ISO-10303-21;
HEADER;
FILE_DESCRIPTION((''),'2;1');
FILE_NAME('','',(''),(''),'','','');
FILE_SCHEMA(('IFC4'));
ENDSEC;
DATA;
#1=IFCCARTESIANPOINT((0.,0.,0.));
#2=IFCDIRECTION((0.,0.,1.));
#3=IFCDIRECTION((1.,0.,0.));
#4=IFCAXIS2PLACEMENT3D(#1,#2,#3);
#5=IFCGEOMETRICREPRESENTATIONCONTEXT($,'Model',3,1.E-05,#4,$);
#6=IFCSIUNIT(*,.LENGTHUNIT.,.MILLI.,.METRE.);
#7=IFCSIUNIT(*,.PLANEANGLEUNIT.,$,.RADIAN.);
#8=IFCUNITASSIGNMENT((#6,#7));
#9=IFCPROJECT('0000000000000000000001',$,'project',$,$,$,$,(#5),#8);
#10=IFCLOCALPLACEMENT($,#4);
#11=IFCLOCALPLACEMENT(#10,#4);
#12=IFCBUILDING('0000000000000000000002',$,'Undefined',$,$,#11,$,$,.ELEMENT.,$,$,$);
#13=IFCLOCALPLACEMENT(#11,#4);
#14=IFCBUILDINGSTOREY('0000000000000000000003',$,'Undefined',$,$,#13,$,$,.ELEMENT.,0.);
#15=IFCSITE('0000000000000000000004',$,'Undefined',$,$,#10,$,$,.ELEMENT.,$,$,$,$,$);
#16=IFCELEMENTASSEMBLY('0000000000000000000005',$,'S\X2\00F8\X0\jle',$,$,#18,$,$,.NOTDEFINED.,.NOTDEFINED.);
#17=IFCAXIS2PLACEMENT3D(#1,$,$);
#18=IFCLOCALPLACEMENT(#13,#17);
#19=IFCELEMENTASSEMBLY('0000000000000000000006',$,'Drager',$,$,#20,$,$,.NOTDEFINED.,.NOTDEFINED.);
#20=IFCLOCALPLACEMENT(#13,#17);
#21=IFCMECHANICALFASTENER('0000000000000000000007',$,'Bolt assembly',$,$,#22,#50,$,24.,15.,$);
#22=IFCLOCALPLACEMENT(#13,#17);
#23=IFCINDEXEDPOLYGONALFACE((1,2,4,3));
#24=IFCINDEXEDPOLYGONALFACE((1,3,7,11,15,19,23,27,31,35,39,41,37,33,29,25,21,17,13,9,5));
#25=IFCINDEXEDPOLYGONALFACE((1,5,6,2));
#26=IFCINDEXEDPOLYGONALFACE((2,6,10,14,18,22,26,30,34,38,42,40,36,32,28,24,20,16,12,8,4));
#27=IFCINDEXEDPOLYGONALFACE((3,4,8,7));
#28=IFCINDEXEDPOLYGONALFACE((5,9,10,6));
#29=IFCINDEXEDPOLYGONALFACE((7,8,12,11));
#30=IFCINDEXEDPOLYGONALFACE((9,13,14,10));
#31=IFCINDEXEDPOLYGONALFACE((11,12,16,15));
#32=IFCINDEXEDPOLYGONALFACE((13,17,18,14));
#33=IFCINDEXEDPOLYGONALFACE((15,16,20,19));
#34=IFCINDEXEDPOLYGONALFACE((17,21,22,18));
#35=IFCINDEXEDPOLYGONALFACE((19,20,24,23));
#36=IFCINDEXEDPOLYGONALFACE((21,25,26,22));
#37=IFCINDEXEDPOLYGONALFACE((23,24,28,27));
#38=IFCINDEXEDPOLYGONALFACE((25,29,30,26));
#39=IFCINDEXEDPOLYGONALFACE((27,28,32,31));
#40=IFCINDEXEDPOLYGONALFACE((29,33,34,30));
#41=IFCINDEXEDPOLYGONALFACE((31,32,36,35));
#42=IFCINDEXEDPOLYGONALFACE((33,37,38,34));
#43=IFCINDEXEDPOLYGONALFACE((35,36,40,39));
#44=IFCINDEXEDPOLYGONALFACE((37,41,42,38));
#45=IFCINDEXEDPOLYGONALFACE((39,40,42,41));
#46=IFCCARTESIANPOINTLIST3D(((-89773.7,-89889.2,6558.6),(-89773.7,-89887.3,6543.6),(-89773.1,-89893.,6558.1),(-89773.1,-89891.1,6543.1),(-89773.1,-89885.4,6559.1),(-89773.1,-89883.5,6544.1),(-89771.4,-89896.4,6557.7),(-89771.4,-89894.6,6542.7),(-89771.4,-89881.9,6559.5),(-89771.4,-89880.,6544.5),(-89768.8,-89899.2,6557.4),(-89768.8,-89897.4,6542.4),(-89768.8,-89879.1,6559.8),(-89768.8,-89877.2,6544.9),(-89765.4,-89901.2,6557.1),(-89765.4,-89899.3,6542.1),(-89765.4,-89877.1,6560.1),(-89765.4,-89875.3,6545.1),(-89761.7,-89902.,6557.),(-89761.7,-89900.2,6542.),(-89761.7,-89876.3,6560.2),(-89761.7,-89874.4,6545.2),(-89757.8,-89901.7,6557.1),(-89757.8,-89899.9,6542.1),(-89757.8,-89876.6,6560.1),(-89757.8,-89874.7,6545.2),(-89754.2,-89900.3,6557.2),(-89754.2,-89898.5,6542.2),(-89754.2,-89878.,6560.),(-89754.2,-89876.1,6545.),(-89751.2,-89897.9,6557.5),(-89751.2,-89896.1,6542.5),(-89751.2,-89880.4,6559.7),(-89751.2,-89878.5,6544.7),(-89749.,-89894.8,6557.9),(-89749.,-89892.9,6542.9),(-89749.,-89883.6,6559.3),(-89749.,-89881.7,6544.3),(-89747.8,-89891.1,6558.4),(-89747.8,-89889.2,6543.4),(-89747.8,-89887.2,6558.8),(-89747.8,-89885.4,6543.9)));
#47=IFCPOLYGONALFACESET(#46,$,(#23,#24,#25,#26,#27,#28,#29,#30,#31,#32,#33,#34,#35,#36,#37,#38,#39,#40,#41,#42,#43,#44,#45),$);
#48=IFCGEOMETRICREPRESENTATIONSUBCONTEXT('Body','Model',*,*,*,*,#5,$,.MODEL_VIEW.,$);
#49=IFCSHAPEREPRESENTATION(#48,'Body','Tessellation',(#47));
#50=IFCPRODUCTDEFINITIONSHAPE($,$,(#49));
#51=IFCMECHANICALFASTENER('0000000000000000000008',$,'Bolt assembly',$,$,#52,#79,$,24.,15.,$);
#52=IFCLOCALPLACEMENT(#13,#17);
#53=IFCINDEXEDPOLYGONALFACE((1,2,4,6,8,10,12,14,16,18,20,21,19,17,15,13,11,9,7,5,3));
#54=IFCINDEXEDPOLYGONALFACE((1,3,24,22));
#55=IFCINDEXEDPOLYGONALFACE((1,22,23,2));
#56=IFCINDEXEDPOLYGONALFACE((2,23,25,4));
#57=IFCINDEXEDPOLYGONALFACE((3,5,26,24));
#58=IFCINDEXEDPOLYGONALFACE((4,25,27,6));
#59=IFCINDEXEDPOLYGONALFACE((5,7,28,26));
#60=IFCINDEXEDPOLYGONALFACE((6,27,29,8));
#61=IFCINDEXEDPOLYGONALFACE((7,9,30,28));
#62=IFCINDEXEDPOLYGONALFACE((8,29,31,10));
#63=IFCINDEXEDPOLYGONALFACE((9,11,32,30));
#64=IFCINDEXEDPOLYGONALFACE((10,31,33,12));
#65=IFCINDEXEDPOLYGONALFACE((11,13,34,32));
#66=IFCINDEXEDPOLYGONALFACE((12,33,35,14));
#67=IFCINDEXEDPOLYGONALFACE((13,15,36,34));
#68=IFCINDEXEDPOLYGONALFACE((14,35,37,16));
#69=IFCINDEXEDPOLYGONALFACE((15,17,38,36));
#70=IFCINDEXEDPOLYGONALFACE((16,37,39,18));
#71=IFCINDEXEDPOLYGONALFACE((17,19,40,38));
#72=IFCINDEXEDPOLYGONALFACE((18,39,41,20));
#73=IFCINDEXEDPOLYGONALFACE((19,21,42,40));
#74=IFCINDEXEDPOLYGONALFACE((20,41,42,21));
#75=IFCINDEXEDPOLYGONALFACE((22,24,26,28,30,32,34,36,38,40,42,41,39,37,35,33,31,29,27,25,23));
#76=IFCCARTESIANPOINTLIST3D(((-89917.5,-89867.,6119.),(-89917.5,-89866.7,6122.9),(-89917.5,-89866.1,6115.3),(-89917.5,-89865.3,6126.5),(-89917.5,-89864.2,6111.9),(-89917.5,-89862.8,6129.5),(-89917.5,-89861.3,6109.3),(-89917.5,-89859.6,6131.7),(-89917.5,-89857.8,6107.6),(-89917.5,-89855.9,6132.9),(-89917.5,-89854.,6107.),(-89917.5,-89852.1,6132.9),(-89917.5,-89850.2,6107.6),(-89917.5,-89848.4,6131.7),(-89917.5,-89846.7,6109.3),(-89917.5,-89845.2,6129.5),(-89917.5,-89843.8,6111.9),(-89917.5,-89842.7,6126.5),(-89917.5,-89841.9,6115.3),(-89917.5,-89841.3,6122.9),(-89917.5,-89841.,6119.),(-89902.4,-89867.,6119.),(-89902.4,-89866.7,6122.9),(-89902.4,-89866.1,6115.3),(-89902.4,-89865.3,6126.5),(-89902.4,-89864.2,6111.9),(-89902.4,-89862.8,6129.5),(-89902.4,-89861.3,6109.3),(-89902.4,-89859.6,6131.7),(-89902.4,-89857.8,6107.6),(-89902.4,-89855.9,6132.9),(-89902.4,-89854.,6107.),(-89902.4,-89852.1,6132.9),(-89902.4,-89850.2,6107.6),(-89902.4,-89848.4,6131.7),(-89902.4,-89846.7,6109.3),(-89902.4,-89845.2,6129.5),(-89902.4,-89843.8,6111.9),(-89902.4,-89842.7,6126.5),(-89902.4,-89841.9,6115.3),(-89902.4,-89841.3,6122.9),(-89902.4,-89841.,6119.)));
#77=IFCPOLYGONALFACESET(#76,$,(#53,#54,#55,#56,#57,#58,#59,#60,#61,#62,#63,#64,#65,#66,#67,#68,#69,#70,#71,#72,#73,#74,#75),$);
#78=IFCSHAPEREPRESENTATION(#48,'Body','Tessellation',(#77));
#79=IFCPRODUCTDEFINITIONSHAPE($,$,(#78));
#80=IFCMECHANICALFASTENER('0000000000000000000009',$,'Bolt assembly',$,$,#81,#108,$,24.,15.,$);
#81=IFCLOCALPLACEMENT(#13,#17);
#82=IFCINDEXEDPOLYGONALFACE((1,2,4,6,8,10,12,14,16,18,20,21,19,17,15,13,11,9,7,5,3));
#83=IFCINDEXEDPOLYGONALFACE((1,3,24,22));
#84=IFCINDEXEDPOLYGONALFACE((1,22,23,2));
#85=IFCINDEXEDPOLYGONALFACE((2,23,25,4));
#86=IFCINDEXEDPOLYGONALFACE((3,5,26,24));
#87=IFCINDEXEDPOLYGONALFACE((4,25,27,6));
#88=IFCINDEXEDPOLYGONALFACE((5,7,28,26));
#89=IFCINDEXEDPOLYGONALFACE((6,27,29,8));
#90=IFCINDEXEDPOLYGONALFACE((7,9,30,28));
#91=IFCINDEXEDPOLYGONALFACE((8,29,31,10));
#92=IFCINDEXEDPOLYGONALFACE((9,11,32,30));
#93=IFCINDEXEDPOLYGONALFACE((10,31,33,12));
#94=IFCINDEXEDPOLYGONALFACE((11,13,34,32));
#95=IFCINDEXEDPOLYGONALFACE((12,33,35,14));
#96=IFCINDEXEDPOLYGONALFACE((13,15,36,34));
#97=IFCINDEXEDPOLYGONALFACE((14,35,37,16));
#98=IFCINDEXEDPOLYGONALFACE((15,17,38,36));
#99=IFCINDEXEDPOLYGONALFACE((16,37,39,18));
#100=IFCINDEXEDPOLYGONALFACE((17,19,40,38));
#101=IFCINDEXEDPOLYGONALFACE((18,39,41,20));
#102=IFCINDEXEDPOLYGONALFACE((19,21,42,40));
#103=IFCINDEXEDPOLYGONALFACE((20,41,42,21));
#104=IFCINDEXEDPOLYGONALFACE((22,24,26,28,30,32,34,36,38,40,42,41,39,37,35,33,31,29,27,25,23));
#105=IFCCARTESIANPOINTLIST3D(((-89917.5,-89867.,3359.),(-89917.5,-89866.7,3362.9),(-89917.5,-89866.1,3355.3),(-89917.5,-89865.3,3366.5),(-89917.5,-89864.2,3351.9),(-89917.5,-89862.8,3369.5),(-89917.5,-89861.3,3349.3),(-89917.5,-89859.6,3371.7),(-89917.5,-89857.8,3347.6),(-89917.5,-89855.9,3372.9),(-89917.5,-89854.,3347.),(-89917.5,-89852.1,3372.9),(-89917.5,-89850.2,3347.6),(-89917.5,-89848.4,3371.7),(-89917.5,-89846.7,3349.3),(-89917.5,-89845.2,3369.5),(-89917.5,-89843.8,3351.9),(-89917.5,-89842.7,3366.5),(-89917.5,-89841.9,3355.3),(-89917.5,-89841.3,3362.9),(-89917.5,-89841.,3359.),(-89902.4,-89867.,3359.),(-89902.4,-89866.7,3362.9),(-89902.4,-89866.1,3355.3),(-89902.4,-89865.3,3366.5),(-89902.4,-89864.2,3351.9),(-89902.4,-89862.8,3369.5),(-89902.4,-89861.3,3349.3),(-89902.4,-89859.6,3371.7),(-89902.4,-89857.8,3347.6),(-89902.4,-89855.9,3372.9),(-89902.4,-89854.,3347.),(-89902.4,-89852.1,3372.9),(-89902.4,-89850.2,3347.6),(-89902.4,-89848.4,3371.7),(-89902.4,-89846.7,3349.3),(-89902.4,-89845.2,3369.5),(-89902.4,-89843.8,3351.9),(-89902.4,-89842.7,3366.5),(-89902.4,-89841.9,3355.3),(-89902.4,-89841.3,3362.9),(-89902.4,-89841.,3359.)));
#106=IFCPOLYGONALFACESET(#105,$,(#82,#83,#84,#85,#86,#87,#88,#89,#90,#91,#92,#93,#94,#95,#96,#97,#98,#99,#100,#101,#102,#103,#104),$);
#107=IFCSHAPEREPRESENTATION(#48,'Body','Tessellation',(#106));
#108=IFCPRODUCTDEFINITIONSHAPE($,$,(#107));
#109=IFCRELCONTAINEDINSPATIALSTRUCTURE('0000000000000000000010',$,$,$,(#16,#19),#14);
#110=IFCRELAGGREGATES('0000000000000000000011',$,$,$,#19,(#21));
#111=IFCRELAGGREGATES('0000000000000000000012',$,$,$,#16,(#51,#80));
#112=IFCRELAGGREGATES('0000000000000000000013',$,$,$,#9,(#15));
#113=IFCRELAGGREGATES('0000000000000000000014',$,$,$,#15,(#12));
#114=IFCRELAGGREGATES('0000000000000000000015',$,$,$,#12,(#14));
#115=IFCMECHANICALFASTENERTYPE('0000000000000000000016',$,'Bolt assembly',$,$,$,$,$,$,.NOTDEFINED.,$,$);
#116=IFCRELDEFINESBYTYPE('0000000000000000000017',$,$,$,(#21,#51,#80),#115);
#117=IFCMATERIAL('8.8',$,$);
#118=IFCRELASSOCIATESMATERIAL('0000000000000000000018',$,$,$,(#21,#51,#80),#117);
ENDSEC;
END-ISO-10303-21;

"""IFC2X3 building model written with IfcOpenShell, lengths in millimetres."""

from ifc_helpers import new_model, si_unit, frame, origin_with_axes, origin_2d_with_axis, place, context, subcontext, project, spatial, circle, extrude, source, transform, mapped, material, type_object, element, aggregate, save


model = new_model("IFC2X3")

# Units and contexts
model_context = context("Model", 3, precision=1e-05, world=origin_with_axes())
body_context = subcontext(model_context, "Body", "Model", "MODEL_VIEW")
ifc_project = project(units=[si_unit("LENGTHUNIT", "METRE", prefix="MILLI"), si_unit("PLANEANGLEUNIT", "RADIAN")], contexts=[model_context])

# Site, building, storey
site_placement = place(None, origin_with_axes())
site = spatial("IfcSite", under=ifc_project, at=site_placement, Name="Undefined", CompositionType="ELEMENT")
building_placement = place(site_placement, origin_with_axes())
building = spatial("IfcBuilding", under=site, at=building_placement, Name="Undefined", CompositionType="ELEMENT")
storey_placement = place(building_placement, origin_with_axes())
storey = spatial("IfcBuildingStorey", under=building, at=storey_placement, Name="Undefined", CompositionType="ELEMENT", Elevation=0.0)

# Element assembly
assembly_1_placement = place(storey_placement, origin_with_axes())
assembly_1 = element("IfcElementAssembly", 1, at=assembly_1_placement, inside=storey, Name="Søjle", AssemblyPlace="NOTDEFINED", PredefinedType="NOTDEFINED")

# Element assembly
assembly_2_placement = place(storey_placement, origin_with_axes())
assembly_2 = element("IfcElementAssembly", 2, at=assembly_2_placement, inside=storey, Name="Drager", AssemblyPlace="NOTDEFINED", PredefinedType="NOTDEFINED")

# Mechanical fasteners
ifc_material_1 = material(Name="8.8")
mechanical_fastener_type = type_object("IfcMechanicalFastenerType", Name="Bolt assembly")
shared_shape_1 = source(origin_with_axes(), body_context, "Body", "SweptSolid", [
    extrude(circle(Radius=13.0, at=origin_2d_with_axis()), frame((0.0, -7.5, 0.0), z_axis=(0.0, 1.0, 0.0), x_axis=(1.0, 0.0, 0.0)), (0.0, 0.0, 1.0), 15.1),
])
mechanical_fastener_1_placement = place(assembly_2_placement, frame((-89760.7, -89888.2, 6551.2), z_axis=(0.0, -0.992546, -0.121869), x_axis=(-1.0, 0.0, 0.0)))
mechanical_fastener_1 = element("IfcMechanicalFastener", 3, at=mechanical_fastener_1_placement, type_object=mechanical_fastener_type, material=ifc_material_1, Name="Bolt assembly", NominalDiameter=24.0, NominalLength=15.0, context=body_context, shape_type="MappedRepresentation", body=[
    mapped(shared_shape_1, transform((0.0, 0.0, 0.0))),
])
aggregate(assembly_2, [mechanical_fastener_1])
shared_shape_2 = source(origin_with_axes(), body_context, "Body", "SweptSolid", [
    extrude(circle(Radius=13.0, at=origin_2d_with_axis()), frame((0.0, -7.5, 0.0), z_axis=(0.0, 1.0, 0.0), x_axis=(1.0, 0.0, 0.0)), (0.0, 0.0, 1.0), 15.1),
])
mechanical_fastener_2_placement = place(assembly_1_placement, frame((-89910.0, -89854.0, 6120.0), z_axis=(0.0, -1.0, 0.0), x_axis=(0.0, 0.0, -1.0)))
mechanical_fastener_2 = element("IfcMechanicalFastener", 4, at=mechanical_fastener_2_placement, type_object=mechanical_fastener_type, material=ifc_material_1, Name="Bolt assembly", NominalDiameter=24.0, NominalLength=15.0, context=body_context, shape_type="MappedRepresentation", body=[
    mapped(shared_shape_2, transform((0.0, 0.0, 0.0))),
])
mechanical_fastener_3_placement = place(assembly_1_placement, frame((-89910.0, -89854.0, 3360.0), z_axis=(0.0, -1.0, 0.0), x_axis=(0.0, 0.0, -1.0)))
mechanical_fastener_3 = element("IfcMechanicalFastener", 5, at=mechanical_fastener_3_placement, type_object=mechanical_fastener_type, material=ifc_material_1, Name="Bolt assembly", NominalDiameter=24.0, NominalLength=15.0, context=body_context, shape_type="MappedRepresentation", body=[
    mapped(shared_shape_2, transform((0.0, 0.0, 0.0))),
])
aggregate(assembly_1, [mechanical_fastener_2, mechanical_fastener_3])

save(model, "model.ifc")
